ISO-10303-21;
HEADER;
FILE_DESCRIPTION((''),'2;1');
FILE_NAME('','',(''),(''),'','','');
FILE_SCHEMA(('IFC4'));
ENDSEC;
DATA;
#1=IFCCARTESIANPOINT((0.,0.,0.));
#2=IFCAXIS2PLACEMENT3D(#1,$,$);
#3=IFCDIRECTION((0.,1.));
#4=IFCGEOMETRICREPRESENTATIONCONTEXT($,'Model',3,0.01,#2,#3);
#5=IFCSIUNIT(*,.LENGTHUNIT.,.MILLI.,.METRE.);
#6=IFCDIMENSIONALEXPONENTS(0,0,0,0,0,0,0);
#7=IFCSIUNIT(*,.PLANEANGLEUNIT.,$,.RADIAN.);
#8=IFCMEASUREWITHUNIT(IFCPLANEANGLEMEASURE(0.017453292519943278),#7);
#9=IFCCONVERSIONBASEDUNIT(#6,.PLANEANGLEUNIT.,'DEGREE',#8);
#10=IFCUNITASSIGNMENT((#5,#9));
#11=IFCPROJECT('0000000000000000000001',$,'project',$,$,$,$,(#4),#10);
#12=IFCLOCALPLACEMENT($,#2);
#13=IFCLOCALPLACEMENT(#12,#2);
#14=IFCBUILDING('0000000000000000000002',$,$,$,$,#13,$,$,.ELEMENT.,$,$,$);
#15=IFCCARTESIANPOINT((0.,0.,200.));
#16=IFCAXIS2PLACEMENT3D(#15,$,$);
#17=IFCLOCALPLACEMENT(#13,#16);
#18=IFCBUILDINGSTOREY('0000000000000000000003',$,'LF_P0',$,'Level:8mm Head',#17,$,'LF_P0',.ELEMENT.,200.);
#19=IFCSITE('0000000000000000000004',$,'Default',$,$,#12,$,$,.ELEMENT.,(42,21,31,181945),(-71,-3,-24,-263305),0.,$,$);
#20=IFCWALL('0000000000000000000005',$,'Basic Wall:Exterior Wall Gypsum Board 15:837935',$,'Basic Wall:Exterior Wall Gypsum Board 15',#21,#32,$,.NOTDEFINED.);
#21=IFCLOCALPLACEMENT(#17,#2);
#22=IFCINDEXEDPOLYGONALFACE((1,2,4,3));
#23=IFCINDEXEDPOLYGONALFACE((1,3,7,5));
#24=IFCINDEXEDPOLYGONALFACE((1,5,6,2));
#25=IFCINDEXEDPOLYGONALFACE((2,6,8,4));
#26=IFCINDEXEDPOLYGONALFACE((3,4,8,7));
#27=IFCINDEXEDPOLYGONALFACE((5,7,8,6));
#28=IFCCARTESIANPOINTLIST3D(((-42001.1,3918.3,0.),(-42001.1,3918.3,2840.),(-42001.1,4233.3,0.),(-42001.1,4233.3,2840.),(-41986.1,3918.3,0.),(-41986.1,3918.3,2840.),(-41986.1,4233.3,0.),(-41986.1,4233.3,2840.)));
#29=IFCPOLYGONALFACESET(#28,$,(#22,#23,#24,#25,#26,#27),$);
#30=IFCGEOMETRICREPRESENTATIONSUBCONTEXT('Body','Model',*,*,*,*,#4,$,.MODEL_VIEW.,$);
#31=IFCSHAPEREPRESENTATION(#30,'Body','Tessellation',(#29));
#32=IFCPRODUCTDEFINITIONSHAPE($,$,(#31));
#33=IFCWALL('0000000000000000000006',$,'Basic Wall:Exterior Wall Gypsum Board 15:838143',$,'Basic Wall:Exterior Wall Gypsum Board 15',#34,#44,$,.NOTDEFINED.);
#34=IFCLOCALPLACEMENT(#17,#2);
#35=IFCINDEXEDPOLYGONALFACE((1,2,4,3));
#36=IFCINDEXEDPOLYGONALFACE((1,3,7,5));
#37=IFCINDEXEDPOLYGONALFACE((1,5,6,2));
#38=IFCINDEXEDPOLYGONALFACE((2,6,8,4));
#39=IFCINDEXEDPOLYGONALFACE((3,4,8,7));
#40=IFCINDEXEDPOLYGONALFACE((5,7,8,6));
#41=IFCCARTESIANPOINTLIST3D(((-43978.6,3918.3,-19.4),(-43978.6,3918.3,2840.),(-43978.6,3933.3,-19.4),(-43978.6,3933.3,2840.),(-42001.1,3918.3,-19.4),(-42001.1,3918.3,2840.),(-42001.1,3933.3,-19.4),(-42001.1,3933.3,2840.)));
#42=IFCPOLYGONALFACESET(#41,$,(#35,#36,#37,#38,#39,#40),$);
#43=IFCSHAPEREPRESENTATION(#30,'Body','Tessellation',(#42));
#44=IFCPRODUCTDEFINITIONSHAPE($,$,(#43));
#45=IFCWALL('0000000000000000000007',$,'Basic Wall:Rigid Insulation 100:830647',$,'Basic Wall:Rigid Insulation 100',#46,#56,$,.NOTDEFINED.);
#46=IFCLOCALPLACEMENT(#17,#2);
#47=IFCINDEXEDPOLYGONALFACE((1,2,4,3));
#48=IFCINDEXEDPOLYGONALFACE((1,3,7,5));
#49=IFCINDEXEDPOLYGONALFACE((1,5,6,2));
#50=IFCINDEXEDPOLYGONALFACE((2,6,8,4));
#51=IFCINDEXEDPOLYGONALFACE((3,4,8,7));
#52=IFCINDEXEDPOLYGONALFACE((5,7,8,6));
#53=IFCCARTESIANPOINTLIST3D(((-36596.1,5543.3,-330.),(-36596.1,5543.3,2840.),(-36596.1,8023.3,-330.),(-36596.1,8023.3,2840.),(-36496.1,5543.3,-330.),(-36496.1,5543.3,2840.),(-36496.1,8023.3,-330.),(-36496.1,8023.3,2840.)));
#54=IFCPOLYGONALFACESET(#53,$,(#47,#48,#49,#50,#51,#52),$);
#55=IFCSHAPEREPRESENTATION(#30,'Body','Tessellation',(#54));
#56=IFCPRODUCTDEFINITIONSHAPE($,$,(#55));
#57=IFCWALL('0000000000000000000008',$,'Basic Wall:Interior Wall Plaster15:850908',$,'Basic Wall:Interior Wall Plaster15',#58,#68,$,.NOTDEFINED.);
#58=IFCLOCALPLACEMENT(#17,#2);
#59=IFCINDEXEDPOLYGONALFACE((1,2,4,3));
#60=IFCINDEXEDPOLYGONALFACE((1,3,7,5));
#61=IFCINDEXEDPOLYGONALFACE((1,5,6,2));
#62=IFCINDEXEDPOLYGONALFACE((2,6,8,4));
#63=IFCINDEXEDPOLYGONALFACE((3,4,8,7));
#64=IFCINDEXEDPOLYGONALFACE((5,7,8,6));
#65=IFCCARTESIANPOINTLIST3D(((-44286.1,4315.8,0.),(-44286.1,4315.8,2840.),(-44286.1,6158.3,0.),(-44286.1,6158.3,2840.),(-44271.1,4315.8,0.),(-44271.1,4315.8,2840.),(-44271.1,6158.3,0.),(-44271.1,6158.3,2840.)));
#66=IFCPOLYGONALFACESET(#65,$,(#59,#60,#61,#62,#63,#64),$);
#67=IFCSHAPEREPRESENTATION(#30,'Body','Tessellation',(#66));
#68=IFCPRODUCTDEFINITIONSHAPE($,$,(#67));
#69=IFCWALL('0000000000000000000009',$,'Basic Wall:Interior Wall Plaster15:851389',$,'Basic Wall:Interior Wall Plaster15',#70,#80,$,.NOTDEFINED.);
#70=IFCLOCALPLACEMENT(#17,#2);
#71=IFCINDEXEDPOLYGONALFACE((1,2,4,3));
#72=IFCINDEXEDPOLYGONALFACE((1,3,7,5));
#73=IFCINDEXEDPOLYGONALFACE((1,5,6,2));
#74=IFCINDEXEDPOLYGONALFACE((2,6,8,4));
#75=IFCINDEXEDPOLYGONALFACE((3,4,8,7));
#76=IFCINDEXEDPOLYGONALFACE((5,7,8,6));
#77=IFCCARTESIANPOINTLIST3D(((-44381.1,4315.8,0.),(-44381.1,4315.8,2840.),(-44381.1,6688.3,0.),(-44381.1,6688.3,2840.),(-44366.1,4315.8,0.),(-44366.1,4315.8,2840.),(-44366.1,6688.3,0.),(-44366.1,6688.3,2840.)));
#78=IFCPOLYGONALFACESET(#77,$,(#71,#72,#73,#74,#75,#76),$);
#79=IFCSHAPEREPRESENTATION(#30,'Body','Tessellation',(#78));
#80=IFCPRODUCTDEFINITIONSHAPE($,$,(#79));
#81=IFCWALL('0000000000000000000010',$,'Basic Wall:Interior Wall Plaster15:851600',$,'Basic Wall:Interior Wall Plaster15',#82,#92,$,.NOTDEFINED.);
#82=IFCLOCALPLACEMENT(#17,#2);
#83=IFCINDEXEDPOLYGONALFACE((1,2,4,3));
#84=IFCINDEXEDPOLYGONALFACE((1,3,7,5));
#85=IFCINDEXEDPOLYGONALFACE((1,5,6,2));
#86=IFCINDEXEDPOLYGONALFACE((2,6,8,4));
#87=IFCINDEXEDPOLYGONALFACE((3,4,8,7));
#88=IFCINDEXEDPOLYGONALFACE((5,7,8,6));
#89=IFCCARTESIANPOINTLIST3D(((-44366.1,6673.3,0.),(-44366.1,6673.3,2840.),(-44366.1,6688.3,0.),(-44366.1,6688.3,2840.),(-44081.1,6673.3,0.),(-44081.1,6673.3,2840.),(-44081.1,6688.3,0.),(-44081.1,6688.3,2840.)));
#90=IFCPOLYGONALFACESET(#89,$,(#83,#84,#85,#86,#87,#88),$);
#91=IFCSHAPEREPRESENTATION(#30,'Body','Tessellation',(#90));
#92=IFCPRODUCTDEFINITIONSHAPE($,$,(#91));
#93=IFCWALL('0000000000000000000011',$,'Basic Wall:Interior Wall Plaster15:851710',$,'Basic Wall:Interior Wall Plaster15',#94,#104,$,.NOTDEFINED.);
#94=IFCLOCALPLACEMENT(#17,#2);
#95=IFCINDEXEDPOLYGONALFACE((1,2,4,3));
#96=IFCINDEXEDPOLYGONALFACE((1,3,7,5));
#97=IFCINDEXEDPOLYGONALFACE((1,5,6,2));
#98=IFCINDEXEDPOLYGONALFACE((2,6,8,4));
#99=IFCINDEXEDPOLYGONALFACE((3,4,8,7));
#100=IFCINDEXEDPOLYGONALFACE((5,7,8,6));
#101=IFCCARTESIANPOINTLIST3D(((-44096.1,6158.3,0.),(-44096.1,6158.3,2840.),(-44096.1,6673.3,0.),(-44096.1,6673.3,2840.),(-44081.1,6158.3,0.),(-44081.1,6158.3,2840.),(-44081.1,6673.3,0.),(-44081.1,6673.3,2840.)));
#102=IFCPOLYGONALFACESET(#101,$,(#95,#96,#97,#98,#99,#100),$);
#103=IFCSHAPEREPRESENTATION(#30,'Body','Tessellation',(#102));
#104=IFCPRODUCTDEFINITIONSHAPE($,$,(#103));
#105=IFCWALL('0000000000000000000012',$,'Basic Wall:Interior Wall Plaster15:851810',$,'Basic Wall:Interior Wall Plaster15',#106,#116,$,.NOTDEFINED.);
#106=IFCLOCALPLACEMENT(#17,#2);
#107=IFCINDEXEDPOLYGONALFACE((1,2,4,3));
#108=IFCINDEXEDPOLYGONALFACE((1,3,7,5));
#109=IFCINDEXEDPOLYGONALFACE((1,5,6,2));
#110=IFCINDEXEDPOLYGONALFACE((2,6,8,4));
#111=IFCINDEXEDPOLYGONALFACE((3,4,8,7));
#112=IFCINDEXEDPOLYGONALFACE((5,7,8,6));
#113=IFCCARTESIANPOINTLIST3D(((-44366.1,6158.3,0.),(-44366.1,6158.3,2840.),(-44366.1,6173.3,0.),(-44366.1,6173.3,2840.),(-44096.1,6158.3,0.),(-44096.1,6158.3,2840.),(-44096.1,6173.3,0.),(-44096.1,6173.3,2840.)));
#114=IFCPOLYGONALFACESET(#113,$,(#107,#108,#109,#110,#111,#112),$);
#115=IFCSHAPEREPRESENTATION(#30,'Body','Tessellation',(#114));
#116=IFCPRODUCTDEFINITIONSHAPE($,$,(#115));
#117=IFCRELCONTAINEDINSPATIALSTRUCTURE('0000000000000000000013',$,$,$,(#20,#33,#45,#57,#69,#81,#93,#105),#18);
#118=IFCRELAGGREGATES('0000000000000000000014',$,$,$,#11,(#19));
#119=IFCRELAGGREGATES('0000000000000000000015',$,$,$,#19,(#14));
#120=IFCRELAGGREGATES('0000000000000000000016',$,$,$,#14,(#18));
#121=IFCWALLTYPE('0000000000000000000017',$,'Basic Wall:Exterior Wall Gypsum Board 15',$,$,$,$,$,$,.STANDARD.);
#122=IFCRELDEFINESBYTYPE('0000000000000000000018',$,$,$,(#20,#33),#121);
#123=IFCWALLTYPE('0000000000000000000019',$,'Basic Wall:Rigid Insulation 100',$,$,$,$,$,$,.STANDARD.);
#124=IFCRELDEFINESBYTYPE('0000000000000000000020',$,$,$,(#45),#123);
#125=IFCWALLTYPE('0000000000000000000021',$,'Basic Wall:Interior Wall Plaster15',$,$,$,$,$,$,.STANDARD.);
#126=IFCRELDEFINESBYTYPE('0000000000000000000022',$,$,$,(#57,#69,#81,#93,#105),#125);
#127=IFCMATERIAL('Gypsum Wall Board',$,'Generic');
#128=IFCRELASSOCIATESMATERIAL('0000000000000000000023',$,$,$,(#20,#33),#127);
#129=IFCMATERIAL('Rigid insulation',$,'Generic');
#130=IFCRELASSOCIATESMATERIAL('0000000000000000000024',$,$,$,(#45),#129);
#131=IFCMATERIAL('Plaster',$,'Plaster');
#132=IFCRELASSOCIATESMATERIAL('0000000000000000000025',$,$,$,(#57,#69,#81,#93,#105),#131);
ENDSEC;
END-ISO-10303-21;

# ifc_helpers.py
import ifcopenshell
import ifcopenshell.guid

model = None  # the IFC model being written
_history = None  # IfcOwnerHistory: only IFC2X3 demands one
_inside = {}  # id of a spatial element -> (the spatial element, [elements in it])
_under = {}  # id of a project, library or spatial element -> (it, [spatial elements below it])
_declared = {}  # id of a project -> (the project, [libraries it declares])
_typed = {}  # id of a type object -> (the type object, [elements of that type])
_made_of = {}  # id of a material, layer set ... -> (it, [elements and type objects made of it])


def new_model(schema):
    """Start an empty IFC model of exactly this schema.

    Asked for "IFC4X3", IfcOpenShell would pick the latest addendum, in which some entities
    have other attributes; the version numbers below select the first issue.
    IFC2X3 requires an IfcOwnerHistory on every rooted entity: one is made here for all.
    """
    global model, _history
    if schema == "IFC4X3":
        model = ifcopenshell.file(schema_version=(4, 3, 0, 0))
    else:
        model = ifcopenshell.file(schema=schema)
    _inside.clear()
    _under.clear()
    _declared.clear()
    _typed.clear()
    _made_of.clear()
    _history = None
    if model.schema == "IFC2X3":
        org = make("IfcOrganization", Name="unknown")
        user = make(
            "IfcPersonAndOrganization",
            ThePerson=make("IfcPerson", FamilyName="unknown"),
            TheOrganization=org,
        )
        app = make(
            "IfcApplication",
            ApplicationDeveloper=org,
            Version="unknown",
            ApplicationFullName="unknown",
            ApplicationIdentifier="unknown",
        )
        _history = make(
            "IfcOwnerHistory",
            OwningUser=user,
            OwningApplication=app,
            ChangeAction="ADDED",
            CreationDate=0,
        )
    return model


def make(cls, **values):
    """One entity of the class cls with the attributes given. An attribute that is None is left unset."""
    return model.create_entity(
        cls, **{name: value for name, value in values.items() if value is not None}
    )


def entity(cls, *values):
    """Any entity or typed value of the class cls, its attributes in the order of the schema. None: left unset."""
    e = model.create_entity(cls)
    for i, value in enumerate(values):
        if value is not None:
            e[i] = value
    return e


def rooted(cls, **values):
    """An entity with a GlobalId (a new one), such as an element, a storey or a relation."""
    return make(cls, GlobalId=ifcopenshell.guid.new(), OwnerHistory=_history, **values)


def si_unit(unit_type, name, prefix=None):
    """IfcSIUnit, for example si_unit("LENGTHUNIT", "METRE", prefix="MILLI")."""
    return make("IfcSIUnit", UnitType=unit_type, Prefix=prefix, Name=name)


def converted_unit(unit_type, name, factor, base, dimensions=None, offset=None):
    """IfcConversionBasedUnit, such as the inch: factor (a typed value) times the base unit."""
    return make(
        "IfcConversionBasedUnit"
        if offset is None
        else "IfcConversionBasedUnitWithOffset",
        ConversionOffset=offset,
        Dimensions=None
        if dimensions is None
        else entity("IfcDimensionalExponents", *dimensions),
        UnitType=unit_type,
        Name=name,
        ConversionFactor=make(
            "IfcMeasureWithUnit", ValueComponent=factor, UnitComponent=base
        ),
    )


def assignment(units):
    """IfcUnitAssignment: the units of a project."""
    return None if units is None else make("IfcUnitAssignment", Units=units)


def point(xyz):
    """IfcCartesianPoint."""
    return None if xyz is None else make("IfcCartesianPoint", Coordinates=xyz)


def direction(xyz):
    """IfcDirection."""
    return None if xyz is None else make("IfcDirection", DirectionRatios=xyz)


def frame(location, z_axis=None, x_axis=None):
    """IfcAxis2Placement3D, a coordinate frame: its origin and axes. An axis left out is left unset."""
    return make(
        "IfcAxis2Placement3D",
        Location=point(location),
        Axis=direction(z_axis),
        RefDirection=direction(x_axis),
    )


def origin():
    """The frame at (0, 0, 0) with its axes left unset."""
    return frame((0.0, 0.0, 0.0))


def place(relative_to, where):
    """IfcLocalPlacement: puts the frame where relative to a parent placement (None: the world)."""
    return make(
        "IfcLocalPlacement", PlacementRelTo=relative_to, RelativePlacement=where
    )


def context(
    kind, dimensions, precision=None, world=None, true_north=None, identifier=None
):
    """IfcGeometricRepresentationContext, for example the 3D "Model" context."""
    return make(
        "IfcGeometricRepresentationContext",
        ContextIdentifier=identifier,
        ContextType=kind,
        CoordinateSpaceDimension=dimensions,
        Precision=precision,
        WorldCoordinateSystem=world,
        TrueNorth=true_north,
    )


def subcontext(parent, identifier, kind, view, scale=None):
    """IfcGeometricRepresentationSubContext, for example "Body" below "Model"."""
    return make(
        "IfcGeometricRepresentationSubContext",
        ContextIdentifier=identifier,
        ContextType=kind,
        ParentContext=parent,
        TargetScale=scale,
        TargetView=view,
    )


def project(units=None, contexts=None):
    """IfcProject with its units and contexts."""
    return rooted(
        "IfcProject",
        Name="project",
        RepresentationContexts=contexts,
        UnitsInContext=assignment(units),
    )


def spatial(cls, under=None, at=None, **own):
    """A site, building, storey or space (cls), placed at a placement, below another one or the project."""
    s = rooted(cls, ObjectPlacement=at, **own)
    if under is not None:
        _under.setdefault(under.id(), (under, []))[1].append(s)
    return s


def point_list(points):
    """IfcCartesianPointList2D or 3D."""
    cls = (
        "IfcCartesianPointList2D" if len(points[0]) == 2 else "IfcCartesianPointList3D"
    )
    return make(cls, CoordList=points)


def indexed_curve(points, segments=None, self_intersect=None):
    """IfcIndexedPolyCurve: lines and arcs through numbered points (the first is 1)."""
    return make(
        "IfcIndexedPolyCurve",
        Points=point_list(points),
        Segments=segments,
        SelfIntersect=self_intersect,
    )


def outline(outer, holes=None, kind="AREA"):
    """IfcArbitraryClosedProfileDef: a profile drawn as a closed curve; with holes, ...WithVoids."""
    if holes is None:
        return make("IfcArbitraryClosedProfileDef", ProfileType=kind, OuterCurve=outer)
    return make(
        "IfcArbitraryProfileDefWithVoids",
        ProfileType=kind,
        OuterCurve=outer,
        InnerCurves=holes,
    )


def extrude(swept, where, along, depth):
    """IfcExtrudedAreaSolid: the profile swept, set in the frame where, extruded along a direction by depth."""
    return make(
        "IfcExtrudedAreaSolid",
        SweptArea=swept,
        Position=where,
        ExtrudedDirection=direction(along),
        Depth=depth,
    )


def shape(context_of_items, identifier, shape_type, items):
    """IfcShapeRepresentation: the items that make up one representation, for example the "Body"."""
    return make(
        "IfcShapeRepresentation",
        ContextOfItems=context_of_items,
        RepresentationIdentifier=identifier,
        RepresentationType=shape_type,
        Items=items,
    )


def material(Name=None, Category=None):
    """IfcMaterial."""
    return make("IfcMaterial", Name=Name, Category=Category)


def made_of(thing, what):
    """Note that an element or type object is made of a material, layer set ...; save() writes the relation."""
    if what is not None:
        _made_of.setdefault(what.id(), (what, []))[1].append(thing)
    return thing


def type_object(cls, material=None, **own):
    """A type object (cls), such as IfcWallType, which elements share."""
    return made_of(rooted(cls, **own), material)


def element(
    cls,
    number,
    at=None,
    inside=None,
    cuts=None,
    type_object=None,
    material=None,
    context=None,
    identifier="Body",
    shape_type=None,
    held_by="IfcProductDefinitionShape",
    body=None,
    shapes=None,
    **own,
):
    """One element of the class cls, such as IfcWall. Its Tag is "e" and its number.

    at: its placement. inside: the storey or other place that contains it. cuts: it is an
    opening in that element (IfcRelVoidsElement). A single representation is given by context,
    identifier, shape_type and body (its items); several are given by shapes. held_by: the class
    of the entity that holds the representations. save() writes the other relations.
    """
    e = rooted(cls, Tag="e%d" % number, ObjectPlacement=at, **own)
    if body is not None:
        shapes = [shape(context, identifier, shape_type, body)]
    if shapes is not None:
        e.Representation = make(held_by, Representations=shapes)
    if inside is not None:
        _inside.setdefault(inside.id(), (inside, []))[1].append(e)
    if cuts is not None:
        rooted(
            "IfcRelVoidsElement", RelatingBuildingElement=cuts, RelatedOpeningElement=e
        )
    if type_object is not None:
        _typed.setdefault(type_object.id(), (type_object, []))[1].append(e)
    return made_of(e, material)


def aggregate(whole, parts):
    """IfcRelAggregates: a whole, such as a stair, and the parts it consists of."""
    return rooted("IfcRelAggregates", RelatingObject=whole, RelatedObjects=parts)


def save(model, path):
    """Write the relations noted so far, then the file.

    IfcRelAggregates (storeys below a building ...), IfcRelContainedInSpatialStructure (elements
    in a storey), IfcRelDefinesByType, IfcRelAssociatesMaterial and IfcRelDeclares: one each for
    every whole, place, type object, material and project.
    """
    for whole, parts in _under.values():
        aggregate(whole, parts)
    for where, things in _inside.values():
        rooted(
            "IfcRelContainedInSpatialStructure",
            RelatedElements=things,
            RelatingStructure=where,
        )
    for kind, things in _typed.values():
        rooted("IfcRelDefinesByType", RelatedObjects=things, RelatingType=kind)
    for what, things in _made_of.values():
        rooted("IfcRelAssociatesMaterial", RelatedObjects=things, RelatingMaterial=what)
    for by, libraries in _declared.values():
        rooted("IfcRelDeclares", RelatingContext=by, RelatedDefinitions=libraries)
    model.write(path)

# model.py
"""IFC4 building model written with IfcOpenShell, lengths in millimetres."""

from ifc_helpers import new_model, entity, si_unit, converted_unit, direction, frame, origin, place, context, subcontext, project, spatial, indexed_curve, outline, extrude, material, type_object, element, save


model = new_model("IFC4")

# Units and contexts
model_context = context("Model", 3, precision=0.01, world=origin(), true_north=direction((0.0, 1.0)))
body_context = subcontext(model_context, "Body", "Model", "MODEL_VIEW")
ifc_project = project(units=[si_unit("LENGTHUNIT", "METRE", prefix="MILLI"), converted_unit("PLANEANGLEUNIT", "DEGREE", entity("IfcPlaneAngleMeasure", 0.017453292519943278), si_unit("PLANEANGLEUNIT", "RADIAN"), dimensions=[0, 0, 0, 0, 0, 0, 0])], contexts=[model_context])

# Site, building, storey
site_placement = place(None, origin())
site = spatial("IfcSite", under=ifc_project, at=site_placement, Name="Default", CompositionType="ELEMENT", RefLatitude=(42, 21, 31, 181945), RefLongitude=(-71, -3, -24, -263305), RefElevation=0.0)
building_placement = place(site_placement, origin())
building = spatial("IfcBuilding", under=site, at=building_placement, CompositionType="ELEMENT")
storey_placement = place(building_placement, frame((0.0, 0.0, 200.0)))
storey = spatial("IfcBuildingStorey", under=building, at=storey_placement, Name="LF_P0", ObjectType="Level:8mm Head", LongName="LF_P0", CompositionType="ELEMENT", Elevation=200.0)

# Walls
ifc_material_1 = material(Name="Plaster", Category="Plaster")
ifc_material_2 = material(Name="Rigid insulation", Category="Generic")
ifc_material_3 = material(Name="Gypsum Wall Board", Category="Generic")
wall_type_1 = type_object("IfcWallType", Name="Basic Wall:Exterior Wall Gypsum Board 15", PredefinedType="STANDARD")
wall_1_placement = place(storey_placement, frame((-41993.6, 4233.3, 0.0), z_axis=(0.0, 0.0, 1.0), x_axis=(0.0, -1.0, 0.0)))
element("IfcWall", 1, at=wall_1_placement, inside=storey, type_object=wall_type_1, material=ifc_material_3, Name="Basic Wall:Exterior Wall Gypsum Board 15:837935", ObjectType="Basic Wall:Exterior Wall Gypsum Board 15", PredefinedType="NOTDEFINED", context=body_context, shape_type="SweptSolid", body=[
    extrude(outline(indexed_curve([(315.0, 7.5), (0.0, 7.5), (0.0, -7.5), (315.0, -7.5), (315.0, 7.5)], self_intersect=False)), origin(), (0.0, 0.0, 1.0), 2840.0),
])
wall_2_placement = place(storey_placement, frame((-42001.1, 3925.8, -19.4), z_axis=(0.0, 0.0, 1.0), x_axis=(-1.0, 0.0, 0.0)))
element("IfcWall", 2, at=wall_2_placement, inside=storey, type_object=wall_type_1, material=ifc_material_3, Name="Basic Wall:Exterior Wall Gypsum Board 15:838143", ObjectType="Basic Wall:Exterior Wall Gypsum Board 15", PredefinedType="NOTDEFINED", context=body_context, shape_type="SweptSolid", body=[
    extrude(outline(indexed_curve([(1977.5, 7.5), (0.0, 7.5), (0.0, -7.5), (1977.5, -7.5), (1977.5, 7.5)], self_intersect=False)), origin(), (0.0, 0.0, 1.0), 2859.4),
])
wall_type_2 = type_object("IfcWallType", Name="Basic Wall:Rigid Insulation 100", PredefinedType="STANDARD")
wall_3_placement = place(storey_placement, frame((-36546.1, 5543.3, -330.0), z_axis=(0.0, 0.0, 1.0), x_axis=(0.0, 1.0, 0.0)))
element("IfcWall", 3, at=wall_3_placement, inside=storey, type_object=wall_type_2, material=ifc_material_2, Name="Basic Wall:Rigid Insulation 100:830647", ObjectType="Basic Wall:Rigid Insulation 100", PredefinedType="NOTDEFINED", context=body_context, shape_type="SweptSolid", body=[
    extrude(outline(indexed_curve([(2480.0, 50.0), (0.0, 50.0), (0.0, -50.0), (2480.0, -50.0), (2480.0, 50.0)], self_intersect=False)), origin(), (0.0, 0.0, 1.0), 3170.0),
])
wall_type_3 = type_object("IfcWallType", Name="Basic Wall:Interior Wall Plaster15", PredefinedType="STANDARD")
wall_4_placement = place(storey_placement, frame((-44278.6, 4315.8, 0.0), z_axis=(0.0, 0.0, 1.0), x_axis=(0.0, 1.0, 0.0)))
element("IfcWall", 4, at=wall_4_placement, inside=storey, type_object=wall_type_3, material=ifc_material_1, Name="Basic Wall:Interior Wall Plaster15:850908", ObjectType="Basic Wall:Interior Wall Plaster15", PredefinedType="NOTDEFINED", context=body_context, shape_type="SweptSolid", body=[
    extrude(outline(indexed_curve([(1842.5, 7.5), (0.0, 7.5), (0.0, -7.5), (1842.5, -7.5), (1842.5, 7.5)], self_intersect=False)), origin(), (0.0, 0.0, 1.0), 2840.0),
])
wall_5_placement = place(storey_placement, frame((-44373.6, 4315.8, 0.0), z_axis=(0.0, 0.0, 1.0), x_axis=(0.0, 1.0, 0.0)))
element("IfcWall", 5, at=wall_5_placement, inside=storey, type_object=wall_type_3, material=ifc_material_1, Name="Basic Wall:Interior Wall Plaster15:851389", ObjectType="Basic Wall:Interior Wall Plaster15", PredefinedType="NOTDEFINED", context=body_context, shape_type="SweptSolid", body=[
    extrude(outline(indexed_curve([(2372.5, 7.5), (0.0, 7.5), (0.0, -7.5), (2372.5, -7.5), (2372.5, 7.5)], self_intersect=False)), origin(), (0.0, 0.0, 1.0), 2840.0),
])
wall_6_placement = place(storey_placement, frame((-44366.1, 6680.8, 0.0)))
element("IfcWall", 6, at=wall_6_placement, inside=storey, type_object=wall_type_3, material=ifc_material_1, Name="Basic Wall:Interior Wall Plaster15:851600", ObjectType="Basic Wall:Interior Wall Plaster15", PredefinedType="NOTDEFINED", context=body_context, shape_type="SweptSolid", body=[
    extrude(outline(indexed_curve([(285.0, 7.5), (0.0, 7.5), (0.0, -7.5), (285.0, -7.5), (285.0, 7.5)], self_intersect=False)), origin(), (0.0, 0.0, 1.0), 2840.0),
])
wall_7_placement = place(storey_placement, frame((-44088.6, 6673.3, 0.0), z_axis=(0.0, 0.0, 1.0), x_axis=(0.0, -1.0, 0.0)))
element("IfcWall", 7, at=wall_7_placement, inside=storey, type_object=wall_type_3, material=ifc_material_1, Name="Basic Wall:Interior Wall Plaster15:851710", ObjectType="Basic Wall:Interior Wall Plaster15", PredefinedType="NOTDEFINED", context=body_context, shape_type="SweptSolid", body=[
    extrude(outline(indexed_curve([(515.0, 7.5), (0.0, 7.5), (0.0, -7.5), (515.0, -7.5), (515.0, 7.5)], self_intersect=False)), origin(), (0.0, 0.0, 1.0), 2840.0),
])
wall_8_placement = place(storey_placement, frame((-44096.1, 6165.8, 0.0), z_axis=(0.0, 0.0, 1.0), x_axis=(-1.0, 0.0, 0.0)))
element("IfcWall", 8, at=wall_8_placement, inside=storey, type_object=wall_type_3, material=ifc_material_1, Name="Basic Wall:Interior Wall Plaster15:851810", ObjectType="Basic Wall:Interior Wall Plaster15", PredefinedType="NOTDEFINED", context=body_context, shape_type="SweptSolid", body=[
    extrude(outline(indexed_curve([(270.0, 7.5), (0.0, 7.5), (0.0, -7.5), (270.0, -7.5), (270.0, 7.5)], self_intersect=False)), origin(), (0.0, 0.0, 1.0), 2840.0),
])

save(model, "model.ifc")
